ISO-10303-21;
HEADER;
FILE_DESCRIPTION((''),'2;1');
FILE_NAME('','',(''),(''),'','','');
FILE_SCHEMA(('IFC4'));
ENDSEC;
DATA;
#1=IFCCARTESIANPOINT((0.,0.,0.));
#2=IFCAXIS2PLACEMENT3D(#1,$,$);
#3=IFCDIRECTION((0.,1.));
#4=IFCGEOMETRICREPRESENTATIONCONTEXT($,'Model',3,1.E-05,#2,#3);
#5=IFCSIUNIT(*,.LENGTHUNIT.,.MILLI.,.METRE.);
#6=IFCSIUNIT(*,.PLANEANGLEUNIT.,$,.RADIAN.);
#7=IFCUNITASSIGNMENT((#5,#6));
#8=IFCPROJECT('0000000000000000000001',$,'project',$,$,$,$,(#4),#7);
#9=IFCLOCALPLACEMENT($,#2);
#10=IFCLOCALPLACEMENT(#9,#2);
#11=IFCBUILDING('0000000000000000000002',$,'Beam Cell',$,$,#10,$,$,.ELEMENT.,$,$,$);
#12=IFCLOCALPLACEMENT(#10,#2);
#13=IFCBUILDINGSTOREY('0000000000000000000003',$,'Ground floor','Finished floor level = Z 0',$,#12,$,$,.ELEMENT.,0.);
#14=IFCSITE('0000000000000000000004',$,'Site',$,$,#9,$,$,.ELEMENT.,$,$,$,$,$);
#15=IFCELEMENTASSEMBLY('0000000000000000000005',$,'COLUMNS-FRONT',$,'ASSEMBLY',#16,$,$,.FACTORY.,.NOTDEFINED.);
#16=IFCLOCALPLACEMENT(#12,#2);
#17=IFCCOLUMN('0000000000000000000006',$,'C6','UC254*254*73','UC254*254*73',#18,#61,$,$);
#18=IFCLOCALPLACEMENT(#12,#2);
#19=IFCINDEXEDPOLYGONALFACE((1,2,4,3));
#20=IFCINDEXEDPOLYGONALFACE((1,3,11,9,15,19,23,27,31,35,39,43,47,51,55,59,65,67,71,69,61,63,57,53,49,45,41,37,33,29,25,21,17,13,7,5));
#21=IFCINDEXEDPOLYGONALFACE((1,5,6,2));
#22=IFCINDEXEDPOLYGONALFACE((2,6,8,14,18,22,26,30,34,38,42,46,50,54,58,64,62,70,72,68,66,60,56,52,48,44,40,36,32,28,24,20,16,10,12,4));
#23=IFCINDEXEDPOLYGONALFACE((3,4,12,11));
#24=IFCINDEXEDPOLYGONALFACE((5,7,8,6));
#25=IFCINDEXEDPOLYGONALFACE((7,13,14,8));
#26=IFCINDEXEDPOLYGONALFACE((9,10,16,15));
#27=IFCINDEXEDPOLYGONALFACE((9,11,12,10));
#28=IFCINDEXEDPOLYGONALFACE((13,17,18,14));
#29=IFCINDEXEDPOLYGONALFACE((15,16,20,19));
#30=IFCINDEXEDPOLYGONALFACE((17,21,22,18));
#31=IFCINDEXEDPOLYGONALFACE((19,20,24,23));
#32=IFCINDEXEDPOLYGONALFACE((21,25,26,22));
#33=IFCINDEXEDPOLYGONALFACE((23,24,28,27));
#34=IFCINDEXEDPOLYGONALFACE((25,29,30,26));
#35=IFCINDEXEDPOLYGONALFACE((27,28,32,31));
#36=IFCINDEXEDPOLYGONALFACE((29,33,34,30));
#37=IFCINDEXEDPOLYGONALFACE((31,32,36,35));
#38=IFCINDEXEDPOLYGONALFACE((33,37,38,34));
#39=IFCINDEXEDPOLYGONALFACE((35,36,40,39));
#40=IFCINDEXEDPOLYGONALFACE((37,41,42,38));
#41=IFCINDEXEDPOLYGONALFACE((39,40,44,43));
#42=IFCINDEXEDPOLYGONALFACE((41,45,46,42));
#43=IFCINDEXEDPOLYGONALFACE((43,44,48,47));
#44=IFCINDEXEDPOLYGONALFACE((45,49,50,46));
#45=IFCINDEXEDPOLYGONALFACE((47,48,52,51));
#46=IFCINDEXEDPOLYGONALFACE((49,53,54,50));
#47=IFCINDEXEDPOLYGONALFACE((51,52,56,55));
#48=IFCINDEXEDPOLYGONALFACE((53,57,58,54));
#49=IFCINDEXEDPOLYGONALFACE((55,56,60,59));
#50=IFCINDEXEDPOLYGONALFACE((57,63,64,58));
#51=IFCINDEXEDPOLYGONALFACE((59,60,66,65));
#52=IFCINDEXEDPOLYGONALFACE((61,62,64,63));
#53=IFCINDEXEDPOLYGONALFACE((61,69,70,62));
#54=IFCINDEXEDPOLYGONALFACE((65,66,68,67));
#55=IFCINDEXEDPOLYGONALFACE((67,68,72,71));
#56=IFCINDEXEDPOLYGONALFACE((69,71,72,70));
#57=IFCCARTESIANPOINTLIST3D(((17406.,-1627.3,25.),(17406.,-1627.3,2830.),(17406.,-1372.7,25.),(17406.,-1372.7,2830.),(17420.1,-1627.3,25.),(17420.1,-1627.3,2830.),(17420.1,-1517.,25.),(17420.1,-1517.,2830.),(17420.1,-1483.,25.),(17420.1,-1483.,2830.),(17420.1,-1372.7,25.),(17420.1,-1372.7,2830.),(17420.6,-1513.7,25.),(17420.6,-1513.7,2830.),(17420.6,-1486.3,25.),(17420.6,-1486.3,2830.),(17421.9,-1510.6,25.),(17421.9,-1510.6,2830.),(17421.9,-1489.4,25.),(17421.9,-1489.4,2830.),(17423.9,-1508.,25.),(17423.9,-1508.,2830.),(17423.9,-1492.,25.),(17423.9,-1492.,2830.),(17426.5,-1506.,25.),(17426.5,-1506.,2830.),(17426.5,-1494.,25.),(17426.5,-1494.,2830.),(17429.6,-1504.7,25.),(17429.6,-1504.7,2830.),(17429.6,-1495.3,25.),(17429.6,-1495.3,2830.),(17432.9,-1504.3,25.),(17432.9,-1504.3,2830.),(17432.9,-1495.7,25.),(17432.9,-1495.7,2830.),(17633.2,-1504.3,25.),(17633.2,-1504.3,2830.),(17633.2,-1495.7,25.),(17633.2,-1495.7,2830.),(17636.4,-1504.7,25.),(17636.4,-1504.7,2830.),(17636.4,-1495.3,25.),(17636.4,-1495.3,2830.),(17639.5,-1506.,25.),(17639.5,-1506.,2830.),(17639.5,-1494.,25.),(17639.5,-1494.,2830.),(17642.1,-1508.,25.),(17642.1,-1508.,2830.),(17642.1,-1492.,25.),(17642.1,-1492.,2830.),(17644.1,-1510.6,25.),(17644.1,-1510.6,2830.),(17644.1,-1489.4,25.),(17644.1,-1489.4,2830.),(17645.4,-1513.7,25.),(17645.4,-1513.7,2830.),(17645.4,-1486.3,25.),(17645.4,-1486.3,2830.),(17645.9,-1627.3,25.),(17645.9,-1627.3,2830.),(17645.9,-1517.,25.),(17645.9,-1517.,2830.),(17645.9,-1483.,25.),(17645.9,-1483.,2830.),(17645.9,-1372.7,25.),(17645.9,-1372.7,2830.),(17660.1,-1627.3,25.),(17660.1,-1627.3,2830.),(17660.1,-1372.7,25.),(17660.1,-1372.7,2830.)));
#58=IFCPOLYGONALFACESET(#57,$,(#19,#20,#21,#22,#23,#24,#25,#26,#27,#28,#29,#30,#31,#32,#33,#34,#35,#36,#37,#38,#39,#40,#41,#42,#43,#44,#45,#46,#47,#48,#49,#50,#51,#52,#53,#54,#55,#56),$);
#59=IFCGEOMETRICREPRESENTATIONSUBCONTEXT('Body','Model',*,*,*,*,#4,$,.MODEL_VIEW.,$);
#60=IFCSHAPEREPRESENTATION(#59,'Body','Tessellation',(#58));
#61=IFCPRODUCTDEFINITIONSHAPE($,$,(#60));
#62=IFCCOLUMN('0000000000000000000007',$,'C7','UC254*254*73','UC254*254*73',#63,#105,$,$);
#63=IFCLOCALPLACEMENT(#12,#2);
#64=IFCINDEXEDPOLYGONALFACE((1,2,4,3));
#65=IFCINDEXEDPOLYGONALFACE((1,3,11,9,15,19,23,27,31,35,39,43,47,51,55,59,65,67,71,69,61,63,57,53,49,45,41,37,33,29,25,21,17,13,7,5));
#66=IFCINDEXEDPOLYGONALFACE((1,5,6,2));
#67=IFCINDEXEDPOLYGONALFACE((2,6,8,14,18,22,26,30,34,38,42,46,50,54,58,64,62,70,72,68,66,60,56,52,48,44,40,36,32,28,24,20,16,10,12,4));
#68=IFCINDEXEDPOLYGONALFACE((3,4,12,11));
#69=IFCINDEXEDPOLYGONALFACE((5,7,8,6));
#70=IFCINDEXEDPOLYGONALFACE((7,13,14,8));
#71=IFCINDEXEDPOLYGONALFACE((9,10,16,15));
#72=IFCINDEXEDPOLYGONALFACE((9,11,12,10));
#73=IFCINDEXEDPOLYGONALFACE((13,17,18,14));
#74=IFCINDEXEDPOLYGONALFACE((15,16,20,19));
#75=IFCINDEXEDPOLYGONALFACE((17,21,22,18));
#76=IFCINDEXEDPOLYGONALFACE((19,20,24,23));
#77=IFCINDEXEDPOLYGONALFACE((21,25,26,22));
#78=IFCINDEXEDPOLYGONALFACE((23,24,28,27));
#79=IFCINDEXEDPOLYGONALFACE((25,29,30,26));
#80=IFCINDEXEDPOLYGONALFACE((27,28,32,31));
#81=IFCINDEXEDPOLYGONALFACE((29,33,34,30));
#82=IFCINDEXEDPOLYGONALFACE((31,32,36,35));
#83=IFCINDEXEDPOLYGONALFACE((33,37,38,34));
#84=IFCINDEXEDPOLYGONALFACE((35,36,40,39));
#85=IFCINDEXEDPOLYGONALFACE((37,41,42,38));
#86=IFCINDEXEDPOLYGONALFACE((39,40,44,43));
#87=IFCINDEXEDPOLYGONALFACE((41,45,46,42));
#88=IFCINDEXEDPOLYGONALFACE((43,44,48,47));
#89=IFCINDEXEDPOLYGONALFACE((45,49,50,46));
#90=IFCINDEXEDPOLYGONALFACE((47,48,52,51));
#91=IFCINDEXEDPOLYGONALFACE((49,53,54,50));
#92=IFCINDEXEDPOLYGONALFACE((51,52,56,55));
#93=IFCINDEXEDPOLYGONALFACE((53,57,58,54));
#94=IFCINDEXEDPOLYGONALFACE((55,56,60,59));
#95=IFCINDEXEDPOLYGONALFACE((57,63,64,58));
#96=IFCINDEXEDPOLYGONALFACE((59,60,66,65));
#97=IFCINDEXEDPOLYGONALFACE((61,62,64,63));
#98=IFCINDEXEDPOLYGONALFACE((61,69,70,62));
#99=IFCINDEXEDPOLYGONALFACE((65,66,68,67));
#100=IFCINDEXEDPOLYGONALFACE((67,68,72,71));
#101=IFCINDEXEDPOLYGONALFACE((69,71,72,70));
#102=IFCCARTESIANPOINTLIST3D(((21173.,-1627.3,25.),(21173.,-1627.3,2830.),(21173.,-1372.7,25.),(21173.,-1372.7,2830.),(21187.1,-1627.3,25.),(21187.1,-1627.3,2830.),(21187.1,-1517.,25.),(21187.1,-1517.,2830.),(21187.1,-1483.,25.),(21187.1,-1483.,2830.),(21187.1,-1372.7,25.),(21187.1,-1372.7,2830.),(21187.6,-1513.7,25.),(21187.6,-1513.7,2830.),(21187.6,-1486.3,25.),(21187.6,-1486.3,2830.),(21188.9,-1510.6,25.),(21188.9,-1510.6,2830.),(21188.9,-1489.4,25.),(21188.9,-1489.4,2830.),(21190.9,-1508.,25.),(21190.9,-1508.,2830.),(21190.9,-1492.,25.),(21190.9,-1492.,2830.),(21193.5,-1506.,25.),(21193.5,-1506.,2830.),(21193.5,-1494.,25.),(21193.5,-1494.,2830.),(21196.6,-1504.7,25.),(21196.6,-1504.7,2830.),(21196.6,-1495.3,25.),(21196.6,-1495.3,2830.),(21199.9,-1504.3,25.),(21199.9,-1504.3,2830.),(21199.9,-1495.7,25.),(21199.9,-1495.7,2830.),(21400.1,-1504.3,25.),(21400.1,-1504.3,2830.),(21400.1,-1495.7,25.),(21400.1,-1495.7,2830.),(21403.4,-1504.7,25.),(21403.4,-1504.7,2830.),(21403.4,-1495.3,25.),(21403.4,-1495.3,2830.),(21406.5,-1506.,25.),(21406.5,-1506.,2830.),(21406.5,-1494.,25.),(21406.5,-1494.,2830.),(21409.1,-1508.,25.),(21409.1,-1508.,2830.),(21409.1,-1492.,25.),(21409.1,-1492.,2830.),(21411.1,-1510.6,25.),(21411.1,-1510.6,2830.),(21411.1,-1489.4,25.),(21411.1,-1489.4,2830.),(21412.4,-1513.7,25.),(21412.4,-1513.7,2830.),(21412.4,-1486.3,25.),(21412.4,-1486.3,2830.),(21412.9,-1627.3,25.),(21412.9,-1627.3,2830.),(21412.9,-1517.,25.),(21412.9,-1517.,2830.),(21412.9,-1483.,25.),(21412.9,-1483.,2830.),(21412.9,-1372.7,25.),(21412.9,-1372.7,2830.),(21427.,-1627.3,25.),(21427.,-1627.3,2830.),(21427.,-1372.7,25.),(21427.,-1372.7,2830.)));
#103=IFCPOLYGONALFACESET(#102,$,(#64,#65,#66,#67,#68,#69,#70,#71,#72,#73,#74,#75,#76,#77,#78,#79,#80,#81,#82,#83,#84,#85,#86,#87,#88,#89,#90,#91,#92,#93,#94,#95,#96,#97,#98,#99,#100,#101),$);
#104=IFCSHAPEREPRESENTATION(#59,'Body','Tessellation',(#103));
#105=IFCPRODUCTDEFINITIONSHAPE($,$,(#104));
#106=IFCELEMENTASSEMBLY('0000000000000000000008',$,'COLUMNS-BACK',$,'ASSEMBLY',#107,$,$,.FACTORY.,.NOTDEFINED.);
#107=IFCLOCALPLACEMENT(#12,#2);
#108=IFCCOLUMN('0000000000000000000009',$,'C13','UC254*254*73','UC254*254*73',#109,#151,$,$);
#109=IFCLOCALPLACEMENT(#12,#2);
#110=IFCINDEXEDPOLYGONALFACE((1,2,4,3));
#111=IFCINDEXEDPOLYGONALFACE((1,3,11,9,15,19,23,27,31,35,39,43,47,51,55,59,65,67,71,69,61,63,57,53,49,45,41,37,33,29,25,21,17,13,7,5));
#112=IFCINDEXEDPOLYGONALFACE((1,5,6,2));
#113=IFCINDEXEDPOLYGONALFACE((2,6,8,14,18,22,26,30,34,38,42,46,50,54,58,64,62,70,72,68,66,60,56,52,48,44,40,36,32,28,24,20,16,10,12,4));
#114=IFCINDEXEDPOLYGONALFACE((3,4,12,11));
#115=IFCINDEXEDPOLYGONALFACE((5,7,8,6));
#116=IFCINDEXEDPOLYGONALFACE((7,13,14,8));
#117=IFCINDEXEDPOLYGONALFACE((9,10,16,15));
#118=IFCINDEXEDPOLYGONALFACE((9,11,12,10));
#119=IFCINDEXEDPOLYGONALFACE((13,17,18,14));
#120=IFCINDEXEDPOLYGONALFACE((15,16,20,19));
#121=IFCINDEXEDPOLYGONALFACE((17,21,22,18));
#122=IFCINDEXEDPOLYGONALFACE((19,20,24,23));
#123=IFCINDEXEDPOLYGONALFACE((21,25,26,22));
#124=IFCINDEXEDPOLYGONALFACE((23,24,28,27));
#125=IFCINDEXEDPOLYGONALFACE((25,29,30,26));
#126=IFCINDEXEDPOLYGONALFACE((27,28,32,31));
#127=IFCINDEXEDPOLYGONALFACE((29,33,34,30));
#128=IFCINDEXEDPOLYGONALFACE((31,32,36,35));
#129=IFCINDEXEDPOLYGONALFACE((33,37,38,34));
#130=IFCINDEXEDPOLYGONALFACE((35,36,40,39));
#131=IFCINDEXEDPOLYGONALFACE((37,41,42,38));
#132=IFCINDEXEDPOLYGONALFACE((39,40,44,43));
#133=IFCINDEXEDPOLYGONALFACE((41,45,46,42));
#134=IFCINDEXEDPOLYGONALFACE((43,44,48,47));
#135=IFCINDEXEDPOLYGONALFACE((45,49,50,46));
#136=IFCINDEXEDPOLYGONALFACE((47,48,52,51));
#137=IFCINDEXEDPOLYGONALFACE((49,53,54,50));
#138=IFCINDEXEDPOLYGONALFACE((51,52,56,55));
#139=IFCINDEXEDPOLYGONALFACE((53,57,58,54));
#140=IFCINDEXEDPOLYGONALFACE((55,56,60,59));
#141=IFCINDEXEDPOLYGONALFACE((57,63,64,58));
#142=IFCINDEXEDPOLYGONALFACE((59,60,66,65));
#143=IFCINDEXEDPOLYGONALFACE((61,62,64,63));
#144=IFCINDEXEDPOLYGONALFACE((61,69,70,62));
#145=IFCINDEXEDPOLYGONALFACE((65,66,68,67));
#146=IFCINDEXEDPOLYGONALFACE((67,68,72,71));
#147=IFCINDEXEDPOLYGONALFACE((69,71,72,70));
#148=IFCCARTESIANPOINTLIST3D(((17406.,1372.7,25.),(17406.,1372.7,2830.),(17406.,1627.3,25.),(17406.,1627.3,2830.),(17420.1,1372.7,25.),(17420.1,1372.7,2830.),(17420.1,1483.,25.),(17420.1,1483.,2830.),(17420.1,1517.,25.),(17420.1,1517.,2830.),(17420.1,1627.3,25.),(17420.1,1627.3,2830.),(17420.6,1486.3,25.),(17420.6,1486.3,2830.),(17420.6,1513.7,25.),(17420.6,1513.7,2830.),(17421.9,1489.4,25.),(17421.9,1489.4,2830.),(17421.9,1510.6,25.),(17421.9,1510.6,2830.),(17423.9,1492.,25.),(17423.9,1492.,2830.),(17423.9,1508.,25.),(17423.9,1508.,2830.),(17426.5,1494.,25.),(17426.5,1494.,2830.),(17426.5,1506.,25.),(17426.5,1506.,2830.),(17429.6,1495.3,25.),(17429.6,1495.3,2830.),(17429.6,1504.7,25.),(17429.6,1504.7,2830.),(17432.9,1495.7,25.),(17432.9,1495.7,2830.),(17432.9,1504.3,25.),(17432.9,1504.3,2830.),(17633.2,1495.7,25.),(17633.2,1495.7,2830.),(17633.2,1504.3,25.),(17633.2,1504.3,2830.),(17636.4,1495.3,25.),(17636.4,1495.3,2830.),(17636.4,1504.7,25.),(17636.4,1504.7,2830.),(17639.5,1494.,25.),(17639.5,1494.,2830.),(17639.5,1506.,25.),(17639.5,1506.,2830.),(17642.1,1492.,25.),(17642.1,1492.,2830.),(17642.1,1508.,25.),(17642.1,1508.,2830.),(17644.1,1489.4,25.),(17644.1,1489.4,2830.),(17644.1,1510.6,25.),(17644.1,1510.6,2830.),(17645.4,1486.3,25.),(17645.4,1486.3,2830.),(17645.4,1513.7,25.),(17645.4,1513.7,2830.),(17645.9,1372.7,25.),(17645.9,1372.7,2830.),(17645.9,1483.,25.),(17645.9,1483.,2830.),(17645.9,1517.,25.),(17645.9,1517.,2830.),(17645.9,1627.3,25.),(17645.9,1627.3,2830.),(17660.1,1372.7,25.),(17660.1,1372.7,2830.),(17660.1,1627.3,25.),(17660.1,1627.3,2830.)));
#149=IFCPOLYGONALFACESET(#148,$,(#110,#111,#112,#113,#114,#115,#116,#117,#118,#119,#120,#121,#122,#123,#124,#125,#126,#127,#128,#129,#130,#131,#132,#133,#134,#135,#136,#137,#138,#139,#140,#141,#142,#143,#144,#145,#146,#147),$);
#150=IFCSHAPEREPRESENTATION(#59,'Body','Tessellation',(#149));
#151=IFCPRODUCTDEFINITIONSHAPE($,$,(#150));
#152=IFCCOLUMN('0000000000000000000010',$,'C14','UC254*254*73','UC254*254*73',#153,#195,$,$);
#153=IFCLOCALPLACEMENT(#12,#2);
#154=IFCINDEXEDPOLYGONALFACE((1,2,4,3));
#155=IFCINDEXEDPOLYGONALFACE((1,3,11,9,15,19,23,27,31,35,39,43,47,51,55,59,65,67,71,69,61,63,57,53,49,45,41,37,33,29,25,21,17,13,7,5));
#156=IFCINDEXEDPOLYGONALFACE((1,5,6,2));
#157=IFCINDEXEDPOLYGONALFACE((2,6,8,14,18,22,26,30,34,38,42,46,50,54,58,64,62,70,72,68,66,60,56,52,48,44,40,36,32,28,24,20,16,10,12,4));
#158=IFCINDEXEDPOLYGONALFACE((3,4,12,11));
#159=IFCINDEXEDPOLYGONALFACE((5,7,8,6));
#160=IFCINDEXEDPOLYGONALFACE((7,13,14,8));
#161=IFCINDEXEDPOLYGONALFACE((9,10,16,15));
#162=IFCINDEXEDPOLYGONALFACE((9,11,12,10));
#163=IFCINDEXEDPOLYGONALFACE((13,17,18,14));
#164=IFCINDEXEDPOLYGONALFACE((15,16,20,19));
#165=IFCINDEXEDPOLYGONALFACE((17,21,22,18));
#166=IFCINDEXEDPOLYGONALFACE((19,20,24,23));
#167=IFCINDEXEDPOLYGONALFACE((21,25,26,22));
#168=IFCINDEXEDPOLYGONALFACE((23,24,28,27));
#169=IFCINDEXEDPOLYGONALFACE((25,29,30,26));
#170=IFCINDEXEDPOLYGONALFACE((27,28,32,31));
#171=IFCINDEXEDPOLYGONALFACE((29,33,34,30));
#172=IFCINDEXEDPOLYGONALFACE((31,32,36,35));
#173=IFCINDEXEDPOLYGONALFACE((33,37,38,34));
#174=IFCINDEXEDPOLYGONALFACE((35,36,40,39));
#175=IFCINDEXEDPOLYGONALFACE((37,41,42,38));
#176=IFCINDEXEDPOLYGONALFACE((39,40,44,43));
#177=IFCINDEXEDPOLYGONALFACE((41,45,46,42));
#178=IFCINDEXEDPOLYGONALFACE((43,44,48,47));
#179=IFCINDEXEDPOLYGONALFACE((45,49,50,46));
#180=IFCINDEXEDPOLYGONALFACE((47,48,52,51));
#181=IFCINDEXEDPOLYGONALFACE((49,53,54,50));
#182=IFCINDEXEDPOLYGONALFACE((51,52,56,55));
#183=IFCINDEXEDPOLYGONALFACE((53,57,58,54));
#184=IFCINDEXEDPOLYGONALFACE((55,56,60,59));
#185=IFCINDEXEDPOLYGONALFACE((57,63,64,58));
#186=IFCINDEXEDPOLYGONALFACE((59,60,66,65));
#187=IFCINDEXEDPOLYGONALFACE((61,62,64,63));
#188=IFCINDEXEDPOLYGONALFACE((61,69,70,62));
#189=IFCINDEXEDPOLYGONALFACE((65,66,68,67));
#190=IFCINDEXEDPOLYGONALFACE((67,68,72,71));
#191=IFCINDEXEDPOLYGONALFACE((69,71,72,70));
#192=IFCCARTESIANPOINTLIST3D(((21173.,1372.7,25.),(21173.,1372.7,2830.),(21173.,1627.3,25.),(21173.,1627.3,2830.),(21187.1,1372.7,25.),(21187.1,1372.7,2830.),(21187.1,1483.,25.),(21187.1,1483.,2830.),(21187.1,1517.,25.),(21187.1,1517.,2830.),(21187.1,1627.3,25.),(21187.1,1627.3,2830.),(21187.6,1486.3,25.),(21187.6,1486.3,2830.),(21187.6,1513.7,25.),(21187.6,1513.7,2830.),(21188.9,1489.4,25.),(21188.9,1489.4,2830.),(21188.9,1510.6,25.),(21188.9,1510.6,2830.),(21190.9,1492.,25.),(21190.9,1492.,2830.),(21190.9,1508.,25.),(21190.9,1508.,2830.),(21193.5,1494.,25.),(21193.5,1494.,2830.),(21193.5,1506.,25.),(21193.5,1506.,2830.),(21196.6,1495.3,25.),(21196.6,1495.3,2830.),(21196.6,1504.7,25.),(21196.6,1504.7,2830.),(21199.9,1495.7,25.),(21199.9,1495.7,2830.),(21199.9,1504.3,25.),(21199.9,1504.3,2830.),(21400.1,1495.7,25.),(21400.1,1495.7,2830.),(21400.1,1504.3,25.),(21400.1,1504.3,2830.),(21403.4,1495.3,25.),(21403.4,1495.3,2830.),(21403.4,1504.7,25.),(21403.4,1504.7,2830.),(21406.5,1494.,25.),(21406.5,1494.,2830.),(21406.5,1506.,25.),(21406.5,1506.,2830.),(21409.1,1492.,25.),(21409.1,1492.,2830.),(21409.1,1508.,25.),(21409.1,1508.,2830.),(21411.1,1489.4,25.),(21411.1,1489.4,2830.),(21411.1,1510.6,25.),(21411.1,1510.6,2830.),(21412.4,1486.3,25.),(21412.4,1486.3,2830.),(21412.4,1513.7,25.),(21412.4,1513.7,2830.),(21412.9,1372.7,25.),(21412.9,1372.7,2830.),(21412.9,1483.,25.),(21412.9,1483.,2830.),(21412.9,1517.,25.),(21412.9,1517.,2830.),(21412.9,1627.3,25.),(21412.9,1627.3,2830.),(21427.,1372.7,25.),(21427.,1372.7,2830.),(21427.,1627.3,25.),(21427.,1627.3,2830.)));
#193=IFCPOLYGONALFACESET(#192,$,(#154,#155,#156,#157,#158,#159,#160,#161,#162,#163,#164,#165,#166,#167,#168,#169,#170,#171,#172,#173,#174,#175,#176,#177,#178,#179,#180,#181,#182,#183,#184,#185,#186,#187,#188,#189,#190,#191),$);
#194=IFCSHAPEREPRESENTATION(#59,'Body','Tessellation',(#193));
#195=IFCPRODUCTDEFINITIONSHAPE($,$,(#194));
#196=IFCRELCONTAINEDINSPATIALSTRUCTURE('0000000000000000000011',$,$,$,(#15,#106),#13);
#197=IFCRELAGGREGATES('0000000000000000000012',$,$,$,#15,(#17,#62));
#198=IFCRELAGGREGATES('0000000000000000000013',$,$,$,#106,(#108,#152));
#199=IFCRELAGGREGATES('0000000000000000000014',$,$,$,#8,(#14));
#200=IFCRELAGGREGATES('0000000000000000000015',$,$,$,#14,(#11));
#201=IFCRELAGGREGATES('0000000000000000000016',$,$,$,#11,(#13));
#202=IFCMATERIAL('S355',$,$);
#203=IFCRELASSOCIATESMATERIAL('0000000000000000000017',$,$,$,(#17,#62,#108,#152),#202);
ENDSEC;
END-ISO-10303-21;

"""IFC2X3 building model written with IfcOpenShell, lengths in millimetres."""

from ifc_helpers import new_model, si_unit, direction, frame, origin, origin_2d, place, context, subcontext, project, spatial, i_section, extrude, material, element, aggregate, save


model = new_model("IFC2X3")

# Units and contexts
model_context = context("Model", 3, precision=1e-05, world=origin(), true_north=direction((0.0, 1.0)))
body_context = subcontext(model_context, "Body", "Model", "MODEL_VIEW")
ifc_project = project(units=[si_unit("LENGTHUNIT", "METRE", prefix="MILLI"), si_unit("PLANEANGLEUNIT", "RADIAN")], contexts=[model_context])

# Site, building, storey
site_placement = place(None, origin())
site = spatial("IfcSite", under=ifc_project, at=site_placement, Name="Site", CompositionType="ELEMENT")
building_placement = place(site_placement, origin())
building = spatial("IfcBuilding", under=site, at=building_placement, Name="Beam Cell", CompositionType="ELEMENT")
storey_placement = place(building_placement, origin())
storey = spatial("IfcBuildingStorey", under=building, at=storey_placement, Name="Ground floor", Description="Finished floor level = Z 0", CompositionType="ELEMENT", Elevation=0.0)

# Element assemblies, columns
assembly_1_placement = place(storey_placement, origin())
assembly_1 = element("IfcElementAssembly", 1, at=assembly_1_placement, inside=storey, Name="COLUMNS-FRONT", ObjectType="ASSEMBLY", AssemblyPlace="FACTORY", PredefinedType="NOTDEFINED")
ifc_material = material(Name="S355")
column_1_placement = place(storey_placement, frame((17533.0, -1500.0, 25.0), z_axis=(0.0, 0.0, 1.0), x_axis=(0.0, 1.0, 0.0)))
column_1 = element("IfcColumn", 2, at=column_1_placement, material=ifc_material, Name="C6", Description="UC254*254*73", ObjectType="UC254*254*73", context=body_context, shape_type="SweptSolid", body=[
    extrude(i_section(OverallWidth=254.6, OverallDepth=254.1, WebThickness=8.6, FlangeThickness=14.2, FilletRadius=12.7, at=origin_2d()), origin(), (0.0, 0.0, 1.0), 2805.0),
])
column_2_placement = place(storey_placement, frame((21300.0, -1500.0, 25.0), z_axis=(0.0, 0.0, 1.0), x_axis=(0.0, 1.0, 0.0)))
column_2 = element("IfcColumn", 3, at=column_2_placement, material=ifc_material, Name="C7", Description="UC254*254*73", ObjectType="UC254*254*73", context=body_context, shape_type="SweptSolid", body=[
    extrude(i_section(OverallWidth=254.6, OverallDepth=254.1, WebThickness=8.6, FlangeThickness=14.2, FilletRadius=12.7, at=origin_2d()), origin(), (0.0, 0.0, 1.0), 2805.0),
])
assembly_2_placement = place(storey_placement, origin())
assembly_2 = element("IfcElementAssembly", 4, at=assembly_2_placement, inside=storey, Name="COLUMNS-BACK", ObjectType="ASSEMBLY", AssemblyPlace="FACTORY", PredefinedType="NOTDEFINED")
column_3_placement = place(storey_placement, frame((17533.0, 1500.0, 25.0), z_axis=(0.0, 0.0, 1.0), x_axis=(0.0, 1.0, 0.0)))
column_3 = element("IfcColumn", 5, at=column_3_placement, material=ifc_material, Name="C13", Description="UC254*254*73", ObjectType="UC254*254*73", context=body_context, shape_type="SweptSolid", body=[
    extrude(i_section(OverallWidth=254.6, OverallDepth=254.1, WebThickness=8.6, FlangeThickness=14.2, FilletRadius=12.7, at=origin_2d()), origin(), (0.0, 0.0, 1.0), 2805.0),
])
column_4_placement = place(storey_placement, frame((21300.0, 1500.0, 25.0), z_axis=(0.0, 0.0, 1.0), x_axis=(0.0, 1.0, 0.0)))
column_4 = element("IfcColumn", 6, at=column_4_placement, material=ifc_material, Name="C14", Description="UC254*254*73", ObjectType="UC254*254*73", context=body_context, shape_type="SweptSolid", body=[
    extrude(i_section(OverallWidth=254.6, OverallDepth=254.1, WebThickness=8.6, FlangeThickness=14.2, FilletRadius=12.7, at=origin_2d()), origin(), (0.0, 0.0, 1.0), 2805.0),
])

aggregate(assembly_1, [column_1, column_2])
aggregate(assembly_2, [column_3, column_4])

save(model, "model.ifc")
